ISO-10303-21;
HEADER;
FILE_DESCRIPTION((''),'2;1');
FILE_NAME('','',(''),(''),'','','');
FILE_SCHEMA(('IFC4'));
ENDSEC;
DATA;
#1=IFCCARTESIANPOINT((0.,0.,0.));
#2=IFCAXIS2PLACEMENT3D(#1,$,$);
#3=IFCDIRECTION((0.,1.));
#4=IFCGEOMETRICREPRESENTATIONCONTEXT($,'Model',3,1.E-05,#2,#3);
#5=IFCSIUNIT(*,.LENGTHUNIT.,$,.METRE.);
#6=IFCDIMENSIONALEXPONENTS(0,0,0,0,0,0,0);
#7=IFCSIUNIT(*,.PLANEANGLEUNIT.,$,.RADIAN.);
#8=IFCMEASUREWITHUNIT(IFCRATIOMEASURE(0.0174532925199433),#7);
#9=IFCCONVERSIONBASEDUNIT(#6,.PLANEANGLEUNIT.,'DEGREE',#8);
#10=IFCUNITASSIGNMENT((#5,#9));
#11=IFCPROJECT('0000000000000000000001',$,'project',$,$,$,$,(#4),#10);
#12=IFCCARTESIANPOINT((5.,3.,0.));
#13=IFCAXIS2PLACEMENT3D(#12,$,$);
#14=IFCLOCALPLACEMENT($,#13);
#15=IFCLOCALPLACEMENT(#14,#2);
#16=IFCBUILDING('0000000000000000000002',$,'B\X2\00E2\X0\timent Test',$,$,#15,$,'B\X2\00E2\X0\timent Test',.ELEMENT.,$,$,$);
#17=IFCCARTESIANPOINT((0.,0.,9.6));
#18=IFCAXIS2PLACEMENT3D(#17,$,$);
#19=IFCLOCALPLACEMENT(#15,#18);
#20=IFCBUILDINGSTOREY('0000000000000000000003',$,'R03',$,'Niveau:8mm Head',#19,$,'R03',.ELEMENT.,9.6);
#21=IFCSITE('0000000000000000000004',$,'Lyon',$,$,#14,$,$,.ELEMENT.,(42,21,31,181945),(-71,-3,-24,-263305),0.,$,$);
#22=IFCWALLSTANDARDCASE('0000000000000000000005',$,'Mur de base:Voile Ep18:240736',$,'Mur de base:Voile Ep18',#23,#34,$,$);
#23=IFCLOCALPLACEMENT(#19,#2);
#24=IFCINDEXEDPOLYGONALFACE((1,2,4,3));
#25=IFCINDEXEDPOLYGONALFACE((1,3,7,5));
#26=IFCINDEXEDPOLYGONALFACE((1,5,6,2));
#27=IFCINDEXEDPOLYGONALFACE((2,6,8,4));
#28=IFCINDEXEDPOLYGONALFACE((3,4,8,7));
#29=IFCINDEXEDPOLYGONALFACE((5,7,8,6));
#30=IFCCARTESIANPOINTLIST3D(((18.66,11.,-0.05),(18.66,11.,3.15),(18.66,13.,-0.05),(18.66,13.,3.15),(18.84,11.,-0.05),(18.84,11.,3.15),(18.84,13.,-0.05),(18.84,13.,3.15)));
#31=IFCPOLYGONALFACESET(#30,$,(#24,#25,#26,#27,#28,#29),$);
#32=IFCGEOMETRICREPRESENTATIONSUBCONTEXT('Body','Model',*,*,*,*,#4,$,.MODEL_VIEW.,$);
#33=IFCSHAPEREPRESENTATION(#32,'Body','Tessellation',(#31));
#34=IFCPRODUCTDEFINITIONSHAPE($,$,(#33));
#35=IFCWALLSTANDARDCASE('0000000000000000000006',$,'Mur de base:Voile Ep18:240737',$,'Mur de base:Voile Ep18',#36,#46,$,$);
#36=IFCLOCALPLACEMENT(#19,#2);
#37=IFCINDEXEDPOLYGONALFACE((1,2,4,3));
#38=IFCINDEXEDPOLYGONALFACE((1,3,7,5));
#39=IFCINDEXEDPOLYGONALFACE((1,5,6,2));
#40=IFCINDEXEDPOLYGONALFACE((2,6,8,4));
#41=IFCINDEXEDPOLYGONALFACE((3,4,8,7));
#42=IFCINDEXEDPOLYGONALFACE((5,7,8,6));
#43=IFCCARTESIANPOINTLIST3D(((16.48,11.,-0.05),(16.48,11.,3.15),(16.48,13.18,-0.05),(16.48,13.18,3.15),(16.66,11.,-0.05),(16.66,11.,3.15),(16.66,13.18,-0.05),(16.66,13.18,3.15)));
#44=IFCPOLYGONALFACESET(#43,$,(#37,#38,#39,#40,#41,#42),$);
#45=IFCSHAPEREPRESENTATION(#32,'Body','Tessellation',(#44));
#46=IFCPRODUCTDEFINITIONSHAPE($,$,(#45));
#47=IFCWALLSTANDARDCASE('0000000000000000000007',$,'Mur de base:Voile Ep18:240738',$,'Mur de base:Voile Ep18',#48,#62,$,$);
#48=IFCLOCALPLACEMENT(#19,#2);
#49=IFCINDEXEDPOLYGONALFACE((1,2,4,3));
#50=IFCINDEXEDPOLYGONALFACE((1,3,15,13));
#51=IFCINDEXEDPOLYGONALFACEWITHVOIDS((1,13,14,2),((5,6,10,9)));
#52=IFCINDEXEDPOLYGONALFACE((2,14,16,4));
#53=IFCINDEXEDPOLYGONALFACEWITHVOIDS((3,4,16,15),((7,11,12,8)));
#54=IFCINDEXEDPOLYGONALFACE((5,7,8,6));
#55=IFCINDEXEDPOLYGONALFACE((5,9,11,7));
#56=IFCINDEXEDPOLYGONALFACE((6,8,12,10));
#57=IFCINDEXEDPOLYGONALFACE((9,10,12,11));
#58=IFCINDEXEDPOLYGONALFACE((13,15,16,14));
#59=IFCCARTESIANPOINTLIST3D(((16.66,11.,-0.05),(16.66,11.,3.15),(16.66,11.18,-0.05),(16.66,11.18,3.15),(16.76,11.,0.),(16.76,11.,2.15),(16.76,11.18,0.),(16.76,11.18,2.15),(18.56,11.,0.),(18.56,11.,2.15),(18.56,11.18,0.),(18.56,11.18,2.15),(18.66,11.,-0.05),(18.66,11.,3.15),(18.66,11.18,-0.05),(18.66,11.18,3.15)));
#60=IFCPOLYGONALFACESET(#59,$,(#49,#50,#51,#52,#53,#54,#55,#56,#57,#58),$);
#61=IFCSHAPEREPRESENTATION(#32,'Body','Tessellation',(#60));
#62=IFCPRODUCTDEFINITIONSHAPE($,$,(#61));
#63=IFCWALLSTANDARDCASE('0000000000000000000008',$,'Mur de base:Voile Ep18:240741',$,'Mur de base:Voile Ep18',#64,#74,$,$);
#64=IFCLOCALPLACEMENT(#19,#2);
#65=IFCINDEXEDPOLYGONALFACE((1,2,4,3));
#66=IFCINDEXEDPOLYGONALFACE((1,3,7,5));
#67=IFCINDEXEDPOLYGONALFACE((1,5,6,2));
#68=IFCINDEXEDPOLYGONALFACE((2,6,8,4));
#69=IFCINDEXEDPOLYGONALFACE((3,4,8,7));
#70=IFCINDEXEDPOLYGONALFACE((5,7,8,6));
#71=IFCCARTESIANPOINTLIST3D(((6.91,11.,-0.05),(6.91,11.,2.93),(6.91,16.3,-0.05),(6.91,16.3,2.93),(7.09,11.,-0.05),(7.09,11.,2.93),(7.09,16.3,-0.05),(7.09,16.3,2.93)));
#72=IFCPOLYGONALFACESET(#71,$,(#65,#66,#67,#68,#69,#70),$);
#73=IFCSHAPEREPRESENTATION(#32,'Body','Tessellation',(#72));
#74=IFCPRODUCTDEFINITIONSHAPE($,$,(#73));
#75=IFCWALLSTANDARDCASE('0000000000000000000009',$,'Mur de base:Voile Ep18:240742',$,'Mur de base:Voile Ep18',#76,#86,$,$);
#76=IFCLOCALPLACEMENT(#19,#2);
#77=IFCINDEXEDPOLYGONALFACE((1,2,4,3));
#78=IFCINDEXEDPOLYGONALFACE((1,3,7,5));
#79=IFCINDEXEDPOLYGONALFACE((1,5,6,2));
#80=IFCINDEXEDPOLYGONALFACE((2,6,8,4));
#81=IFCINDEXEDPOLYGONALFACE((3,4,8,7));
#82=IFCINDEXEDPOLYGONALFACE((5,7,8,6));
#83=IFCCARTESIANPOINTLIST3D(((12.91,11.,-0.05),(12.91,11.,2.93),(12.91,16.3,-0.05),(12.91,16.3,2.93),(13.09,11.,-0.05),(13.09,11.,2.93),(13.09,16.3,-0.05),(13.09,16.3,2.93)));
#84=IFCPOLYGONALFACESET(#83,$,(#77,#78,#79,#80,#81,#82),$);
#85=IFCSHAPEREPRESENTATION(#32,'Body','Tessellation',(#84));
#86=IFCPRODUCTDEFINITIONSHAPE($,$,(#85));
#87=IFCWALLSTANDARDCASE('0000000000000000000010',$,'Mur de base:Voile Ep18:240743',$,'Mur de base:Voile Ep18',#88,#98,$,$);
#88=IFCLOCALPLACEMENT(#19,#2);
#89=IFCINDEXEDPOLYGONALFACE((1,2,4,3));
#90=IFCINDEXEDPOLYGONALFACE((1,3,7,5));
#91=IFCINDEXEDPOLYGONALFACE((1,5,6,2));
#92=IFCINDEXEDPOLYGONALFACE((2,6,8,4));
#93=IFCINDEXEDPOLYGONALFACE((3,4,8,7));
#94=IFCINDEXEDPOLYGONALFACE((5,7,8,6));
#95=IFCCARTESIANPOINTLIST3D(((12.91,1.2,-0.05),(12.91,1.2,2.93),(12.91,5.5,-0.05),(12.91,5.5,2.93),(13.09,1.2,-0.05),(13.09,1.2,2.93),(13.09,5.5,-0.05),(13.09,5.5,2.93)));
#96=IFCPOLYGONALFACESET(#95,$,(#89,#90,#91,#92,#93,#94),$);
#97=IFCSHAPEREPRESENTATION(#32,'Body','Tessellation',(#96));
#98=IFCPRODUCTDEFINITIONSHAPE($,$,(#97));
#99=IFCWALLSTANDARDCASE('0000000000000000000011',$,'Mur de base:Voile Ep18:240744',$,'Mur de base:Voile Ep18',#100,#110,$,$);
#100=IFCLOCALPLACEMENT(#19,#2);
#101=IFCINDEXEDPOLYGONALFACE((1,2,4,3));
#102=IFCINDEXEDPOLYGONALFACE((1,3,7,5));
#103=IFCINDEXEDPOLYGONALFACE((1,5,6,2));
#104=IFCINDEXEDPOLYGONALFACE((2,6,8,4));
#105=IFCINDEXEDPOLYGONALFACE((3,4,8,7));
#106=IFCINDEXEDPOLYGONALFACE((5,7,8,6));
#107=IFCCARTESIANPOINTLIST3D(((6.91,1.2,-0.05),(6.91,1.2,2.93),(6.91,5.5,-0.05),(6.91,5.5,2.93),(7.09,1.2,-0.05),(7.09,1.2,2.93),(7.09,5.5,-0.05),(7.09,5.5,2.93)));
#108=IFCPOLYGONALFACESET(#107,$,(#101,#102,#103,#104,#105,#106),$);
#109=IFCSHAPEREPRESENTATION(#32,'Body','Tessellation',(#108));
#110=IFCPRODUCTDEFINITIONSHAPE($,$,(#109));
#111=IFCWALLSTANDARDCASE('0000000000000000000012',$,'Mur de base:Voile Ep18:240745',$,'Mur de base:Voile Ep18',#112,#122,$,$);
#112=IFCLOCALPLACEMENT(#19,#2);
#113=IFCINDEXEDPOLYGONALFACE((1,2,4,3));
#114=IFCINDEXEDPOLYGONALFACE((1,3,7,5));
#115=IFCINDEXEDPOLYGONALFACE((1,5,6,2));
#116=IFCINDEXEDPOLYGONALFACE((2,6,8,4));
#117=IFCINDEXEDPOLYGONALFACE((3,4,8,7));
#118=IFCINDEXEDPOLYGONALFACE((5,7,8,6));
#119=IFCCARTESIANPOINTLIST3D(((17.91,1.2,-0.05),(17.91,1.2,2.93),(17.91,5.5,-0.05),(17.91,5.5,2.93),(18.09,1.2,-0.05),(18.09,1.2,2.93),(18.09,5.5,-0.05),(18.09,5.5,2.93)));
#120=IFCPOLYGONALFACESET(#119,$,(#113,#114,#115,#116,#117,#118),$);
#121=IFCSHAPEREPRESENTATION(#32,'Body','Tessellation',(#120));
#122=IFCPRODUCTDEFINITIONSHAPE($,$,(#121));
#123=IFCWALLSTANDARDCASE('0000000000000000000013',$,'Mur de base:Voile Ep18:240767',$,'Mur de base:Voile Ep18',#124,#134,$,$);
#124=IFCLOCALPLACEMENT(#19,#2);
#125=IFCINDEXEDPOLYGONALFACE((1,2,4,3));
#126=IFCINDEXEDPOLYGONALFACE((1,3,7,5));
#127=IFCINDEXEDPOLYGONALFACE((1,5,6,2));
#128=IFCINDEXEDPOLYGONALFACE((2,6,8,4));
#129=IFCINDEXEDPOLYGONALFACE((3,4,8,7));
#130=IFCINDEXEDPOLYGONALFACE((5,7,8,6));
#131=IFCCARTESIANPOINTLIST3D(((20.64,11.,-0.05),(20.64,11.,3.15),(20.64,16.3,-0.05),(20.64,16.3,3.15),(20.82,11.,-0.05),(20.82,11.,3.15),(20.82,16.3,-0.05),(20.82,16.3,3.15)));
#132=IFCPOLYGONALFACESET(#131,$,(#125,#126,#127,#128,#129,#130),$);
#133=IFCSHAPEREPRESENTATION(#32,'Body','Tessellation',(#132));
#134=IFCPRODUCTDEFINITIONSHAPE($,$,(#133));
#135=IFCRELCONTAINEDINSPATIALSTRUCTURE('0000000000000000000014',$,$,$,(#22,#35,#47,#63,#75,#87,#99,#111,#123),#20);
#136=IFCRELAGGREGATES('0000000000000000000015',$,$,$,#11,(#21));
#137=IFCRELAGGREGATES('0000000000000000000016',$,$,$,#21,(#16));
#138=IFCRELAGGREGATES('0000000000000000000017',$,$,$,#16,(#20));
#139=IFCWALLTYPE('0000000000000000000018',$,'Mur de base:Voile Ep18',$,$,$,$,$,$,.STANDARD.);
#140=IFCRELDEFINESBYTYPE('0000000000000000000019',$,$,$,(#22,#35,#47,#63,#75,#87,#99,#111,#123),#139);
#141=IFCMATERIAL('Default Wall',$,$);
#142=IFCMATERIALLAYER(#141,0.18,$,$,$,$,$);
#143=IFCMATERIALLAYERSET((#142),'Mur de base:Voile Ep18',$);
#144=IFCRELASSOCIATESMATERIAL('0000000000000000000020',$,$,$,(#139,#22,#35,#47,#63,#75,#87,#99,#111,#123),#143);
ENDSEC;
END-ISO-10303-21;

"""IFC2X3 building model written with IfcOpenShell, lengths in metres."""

from ifc_helpers import new_model, entity, si_unit, converted_unit, direction, frame, frame_2d, origin, place, context, subcontext, project, spatial, rectangle, extrude, material, layer, layer_set, layer_usage, type_object, element, save


model = new_model("IFC2X3")

# Units and contexts
model_context = context("Model", 3, precision=1e-05, world=origin(), true_north=direction((0.0, 1.0)))
body_context = subcontext(model_context, "Body", "Model", "MODEL_VIEW")
ifc_project = project(units=[si_unit("LENGTHUNIT", "METRE"), converted_unit("PLANEANGLEUNIT", "DEGREE", entity("IfcRatioMeasure", 0.0174532925199433), si_unit("PLANEANGLEUNIT", "RADIAN"), dimensions=[0, 0, 0, 0, 0, 0, 0])], contexts=[model_context])

# Site, building, storey
site_placement = place(None, frame((5.0, 3.0, 0.0)))
site = spatial("IfcSite", under=ifc_project, at=site_placement, Name="Lyon", CompositionType="ELEMENT", RefLatitude=(42, 21, 31, 181945), RefLongitude=(-71, -3, -24, -263305), RefElevation=0.0)
building_placement = place(site_placement, origin())
building = spatial("IfcBuilding", under=site, at=building_placement, Name="Bâtiment Test", LongName="Bâtiment Test", CompositionType="ELEMENT")
storey_placement = place(building_placement, frame((0.0, 0.0, 9.6)))
storey = spatial("IfcBuildingStorey", under=building, at=storey_placement, Name="R03", ObjectType="Niveau:8mm Head", LongName="R03", CompositionType="ELEMENT", Elevation=9.6)

# Shared definitions
ifc_material_1 = material(Name="Default Wall")

# Walls
ifc_layer_1 = layer(ifc_material_1, 0.18)
ifc_layer_set_1 = layer_set([ifc_layer_1], Name="Mur de base:Voile Ep18")
wall_type_1 = type_object("IfcWallType", Name="Mur de base:Voile Ep18", PredefinedType="STANDARD", material=ifc_layer_set_1)
ifc_layer_usage_1 = layer_usage(ifc_layer_set_1, "AXIS2", "NEGATIVE", 0.09)
wall_1_placement = place(storey_placement, frame((18.75, 13.0, -0.05), z_axis=(0.0, 0.0, 1.0), x_axis=(0.0, -1.0, 0.0)))
element("IfcWallStandardCase", 1, at=wall_1_placement, inside=storey, type_object=wall_type_1, material=ifc_layer_usage_1, Name="Mur de base:Voile Ep18:240736", ObjectType="Mur de base:Voile Ep18", context=body_context, shape_type="SweptSolid", body=[
    extrude(rectangle(XDim=2.0, YDim=0.18, at=frame_2d((1.0, 0.0), x_axis=(-1.0, 0.0))), origin(), (0.0, 0.0, 1.0), 3.2),
])
ifc_layer_usage_2 = layer_usage(ifc_layer_set_1, "AXIS2", "NEGATIVE", 0.09)
wall_2_placement = place(storey_placement, frame((16.57, 13.18, -0.05), z_axis=(0.0, 0.0, 1.0), x_axis=(0.0, -1.0, 0.0)))
element("IfcWallStandardCase", 2, at=wall_2_placement, inside=storey, type_object=wall_type_1, material=ifc_layer_usage_2, Name="Mur de base:Voile Ep18:240737", ObjectType="Mur de base:Voile Ep18", context=body_context, shape_type="SweptSolid", body=[
    extrude(rectangle(XDim=2.18, YDim=0.18, at=frame_2d((1.09, 0.0), x_axis=(-1.0, 0.0))), origin(), (0.0, 0.0, 1.0), 3.2),
])

# Wall, opening
ifc_layer_usage_3 = layer_usage(ifc_layer_set_1, "AXIS2", "POSITIVE", -0.09)
wall_3_placement = place(storey_placement, frame((16.66, 11.09, -0.05)))
wall_3 = element("IfcWallStandardCase", 3, at=wall_3_placement, inside=storey, type_object=wall_type_1, material=ifc_layer_usage_3, Name="Mur de base:Voile Ep18:240738", ObjectType="Mur de base:Voile Ep18", context=body_context, shape_type="SweptSolid", body=[
    extrude(rectangle(XDim=2.0, YDim=0.18, at=frame_2d((1.0, 0.0), x_axis=(-1.0, 0.0))), origin(), (0.0, 0.0, 1.0), 3.2),
])
opening_1_placement = place(wall_3_placement, origin())
element("IfcOpeningElement", 4, at=opening_1_placement, cuts=wall_3, ObjectType="Opening", context=body_context, shape_type="SweptSolid", body=[
    extrude(rectangle(XDim=2.15, YDim=1.8, at=frame_2d((0.0, 0.0), x_axis=(0.0, 1.0))), frame((1.0, -0.09, 1.125), z_axis=(0.0, 1.0, 0.0), x_axis=(1.0, 0.0, 0.0)), (0.0, 0.0, 1.0), 0.18),
])

# Walls
ifc_layer_usage_4 = layer_usage(ifc_layer_set_1, "AXIS2", "NEGATIVE", 0.09)
wall_4_placement = place(storey_placement, frame((7.0, 16.3, -0.05), z_axis=(0.0, 0.0, 1.0), x_axis=(0.0, -1.0, 0.0)))
element("IfcWallStandardCase", 5, at=wall_4_placement, inside=storey, type_object=wall_type_1, material=ifc_layer_usage_4, Name="Mur de base:Voile Ep18:240741", ObjectType="Mur de base:Voile Ep18", context=body_context, shape_type="SweptSolid", body=[
    extrude(rectangle(XDim=5.3, YDim=0.18, at=frame_2d((2.65, 0.0), x_axis=(-1.0, 0.0))), origin(), (0.0, 0.0, 1.0), 2.98),
])
ifc_layer_usage_5 = layer_usage(ifc_layer_set_1, "AXIS2", "NEGATIVE", 0.09)
wall_5_placement = place(storey_placement, frame((13.0, 16.3, -0.05), z_axis=(0.0, 0.0, 1.0), x_axis=(0.0, -1.0, 0.0)))
element("IfcWallStandardCase", 6, at=wall_5_placement, inside=storey, type_object=wall_type_1, material=ifc_layer_usage_5, Name="Mur de base:Voile Ep18:240742", ObjectType="Mur de base:Voile Ep18", context=body_context, shape_type="SweptSolid", body=[
    extrude(rectangle(XDim=5.3, YDim=0.18, at=frame_2d((2.65, 0.0), x_axis=(-1.0, 0.0))), origin(), (0.0, 0.0, 1.0), 2.98),
])
ifc_layer_usage_6 = layer_usage(ifc_layer_set_1, "AXIS2", "NEGATIVE", 0.09)
wall_6_placement = place(storey_placement, frame((13.0, 1.2, -0.05), z_axis=(0.0, 0.0, 1.0), x_axis=(0.0, 1.0, 0.0)))
element("IfcWallStandardCase", 7, at=wall_6_placement, inside=storey, type_object=wall_type_1, material=ifc_layer_usage_6, Name="Mur de base:Voile Ep18:240743", ObjectType="Mur de base:Voile Ep18", context=body_context, shape_type="SweptSolid", body=[
    extrude(rectangle(XDim=4.3, YDim=0.18, at=frame_2d((2.15, 0.0), x_axis=(-1.0, 0.0))), origin(), (0.0, 0.0, 1.0), 2.98),
])
ifc_layer_usage_7 = layer_usage(ifc_layer_set_1, "AXIS2", "NEGATIVE", 0.09)
wall_7_placement = place(storey_placement, frame((7.0, 1.2, -0.05), z_axis=(0.0, 0.0, 1.0), x_axis=(0.0, 1.0, 0.0)))
element("IfcWallStandardCase", 8, at=wall_7_placement, inside=storey, type_object=wall_type_1, material=ifc_layer_usage_7, Name="Mur de base:Voile Ep18:240744", ObjectType="Mur de base:Voile Ep18", context=body_context, shape_type="SweptSolid", body=[
    extrude(rectangle(XDim=4.3, YDim=0.18, at=frame_2d((2.15, 0.0), x_axis=(-1.0, 0.0))), origin(), (0.0, 0.0, 1.0), 2.98),
])
ifc_layer_usage_8 = layer_usage(ifc_layer_set_1, "AXIS2", "NEGATIVE", 0.09)
wall_8_placement = place(storey_placement, frame((18.0, 1.2, -0.05), z_axis=(0.0, 0.0, 1.0), x_axis=(0.0, 1.0, 0.0)))
element("IfcWallStandardCase", 9, at=wall_8_placement, inside=storey, type_object=wall_type_1, material=ifc_layer_usage_8, Name="Mur de base:Voile Ep18:240745", ObjectType="Mur de base:Voile Ep18", context=body_context, shape_type="SweptSolid", body=[
    extrude(rectangle(XDim=4.3, YDim=0.18, at=frame_2d((2.15, 0.0), x_axis=(-1.0, 0.0))), origin(), (0.0, 0.0, 1.0), 2.98),
])
ifc_layer_usage_9 = layer_usage(ifc_layer_set_1, "AXIS2", "NEGATIVE", 0.09)
wall_9_placement = place(storey_placement, frame((20.73, 16.3, -0.05), z_axis=(0.0, 0.0, 1.0), x_axis=(0.0, -1.0, 0.0)))
element("IfcWallStandardCase", 10, at=wall_9_placement, inside=storey, type_object=wall_type_1, material=ifc_layer_usage_9, Name="Mur de base:Voile Ep18:240767", ObjectType="Mur de base:Voile Ep18", context=body_context, shape_type="SweptSolid", body=[
    extrude(rectangle(XDim=5.3, YDim=0.18, at=frame_2d((2.65, 0.0), x_axis=(-1.0, 0.0))), origin(), (0.0, 0.0, 1.0), 3.2),
])

save(model, "model.ifc")
